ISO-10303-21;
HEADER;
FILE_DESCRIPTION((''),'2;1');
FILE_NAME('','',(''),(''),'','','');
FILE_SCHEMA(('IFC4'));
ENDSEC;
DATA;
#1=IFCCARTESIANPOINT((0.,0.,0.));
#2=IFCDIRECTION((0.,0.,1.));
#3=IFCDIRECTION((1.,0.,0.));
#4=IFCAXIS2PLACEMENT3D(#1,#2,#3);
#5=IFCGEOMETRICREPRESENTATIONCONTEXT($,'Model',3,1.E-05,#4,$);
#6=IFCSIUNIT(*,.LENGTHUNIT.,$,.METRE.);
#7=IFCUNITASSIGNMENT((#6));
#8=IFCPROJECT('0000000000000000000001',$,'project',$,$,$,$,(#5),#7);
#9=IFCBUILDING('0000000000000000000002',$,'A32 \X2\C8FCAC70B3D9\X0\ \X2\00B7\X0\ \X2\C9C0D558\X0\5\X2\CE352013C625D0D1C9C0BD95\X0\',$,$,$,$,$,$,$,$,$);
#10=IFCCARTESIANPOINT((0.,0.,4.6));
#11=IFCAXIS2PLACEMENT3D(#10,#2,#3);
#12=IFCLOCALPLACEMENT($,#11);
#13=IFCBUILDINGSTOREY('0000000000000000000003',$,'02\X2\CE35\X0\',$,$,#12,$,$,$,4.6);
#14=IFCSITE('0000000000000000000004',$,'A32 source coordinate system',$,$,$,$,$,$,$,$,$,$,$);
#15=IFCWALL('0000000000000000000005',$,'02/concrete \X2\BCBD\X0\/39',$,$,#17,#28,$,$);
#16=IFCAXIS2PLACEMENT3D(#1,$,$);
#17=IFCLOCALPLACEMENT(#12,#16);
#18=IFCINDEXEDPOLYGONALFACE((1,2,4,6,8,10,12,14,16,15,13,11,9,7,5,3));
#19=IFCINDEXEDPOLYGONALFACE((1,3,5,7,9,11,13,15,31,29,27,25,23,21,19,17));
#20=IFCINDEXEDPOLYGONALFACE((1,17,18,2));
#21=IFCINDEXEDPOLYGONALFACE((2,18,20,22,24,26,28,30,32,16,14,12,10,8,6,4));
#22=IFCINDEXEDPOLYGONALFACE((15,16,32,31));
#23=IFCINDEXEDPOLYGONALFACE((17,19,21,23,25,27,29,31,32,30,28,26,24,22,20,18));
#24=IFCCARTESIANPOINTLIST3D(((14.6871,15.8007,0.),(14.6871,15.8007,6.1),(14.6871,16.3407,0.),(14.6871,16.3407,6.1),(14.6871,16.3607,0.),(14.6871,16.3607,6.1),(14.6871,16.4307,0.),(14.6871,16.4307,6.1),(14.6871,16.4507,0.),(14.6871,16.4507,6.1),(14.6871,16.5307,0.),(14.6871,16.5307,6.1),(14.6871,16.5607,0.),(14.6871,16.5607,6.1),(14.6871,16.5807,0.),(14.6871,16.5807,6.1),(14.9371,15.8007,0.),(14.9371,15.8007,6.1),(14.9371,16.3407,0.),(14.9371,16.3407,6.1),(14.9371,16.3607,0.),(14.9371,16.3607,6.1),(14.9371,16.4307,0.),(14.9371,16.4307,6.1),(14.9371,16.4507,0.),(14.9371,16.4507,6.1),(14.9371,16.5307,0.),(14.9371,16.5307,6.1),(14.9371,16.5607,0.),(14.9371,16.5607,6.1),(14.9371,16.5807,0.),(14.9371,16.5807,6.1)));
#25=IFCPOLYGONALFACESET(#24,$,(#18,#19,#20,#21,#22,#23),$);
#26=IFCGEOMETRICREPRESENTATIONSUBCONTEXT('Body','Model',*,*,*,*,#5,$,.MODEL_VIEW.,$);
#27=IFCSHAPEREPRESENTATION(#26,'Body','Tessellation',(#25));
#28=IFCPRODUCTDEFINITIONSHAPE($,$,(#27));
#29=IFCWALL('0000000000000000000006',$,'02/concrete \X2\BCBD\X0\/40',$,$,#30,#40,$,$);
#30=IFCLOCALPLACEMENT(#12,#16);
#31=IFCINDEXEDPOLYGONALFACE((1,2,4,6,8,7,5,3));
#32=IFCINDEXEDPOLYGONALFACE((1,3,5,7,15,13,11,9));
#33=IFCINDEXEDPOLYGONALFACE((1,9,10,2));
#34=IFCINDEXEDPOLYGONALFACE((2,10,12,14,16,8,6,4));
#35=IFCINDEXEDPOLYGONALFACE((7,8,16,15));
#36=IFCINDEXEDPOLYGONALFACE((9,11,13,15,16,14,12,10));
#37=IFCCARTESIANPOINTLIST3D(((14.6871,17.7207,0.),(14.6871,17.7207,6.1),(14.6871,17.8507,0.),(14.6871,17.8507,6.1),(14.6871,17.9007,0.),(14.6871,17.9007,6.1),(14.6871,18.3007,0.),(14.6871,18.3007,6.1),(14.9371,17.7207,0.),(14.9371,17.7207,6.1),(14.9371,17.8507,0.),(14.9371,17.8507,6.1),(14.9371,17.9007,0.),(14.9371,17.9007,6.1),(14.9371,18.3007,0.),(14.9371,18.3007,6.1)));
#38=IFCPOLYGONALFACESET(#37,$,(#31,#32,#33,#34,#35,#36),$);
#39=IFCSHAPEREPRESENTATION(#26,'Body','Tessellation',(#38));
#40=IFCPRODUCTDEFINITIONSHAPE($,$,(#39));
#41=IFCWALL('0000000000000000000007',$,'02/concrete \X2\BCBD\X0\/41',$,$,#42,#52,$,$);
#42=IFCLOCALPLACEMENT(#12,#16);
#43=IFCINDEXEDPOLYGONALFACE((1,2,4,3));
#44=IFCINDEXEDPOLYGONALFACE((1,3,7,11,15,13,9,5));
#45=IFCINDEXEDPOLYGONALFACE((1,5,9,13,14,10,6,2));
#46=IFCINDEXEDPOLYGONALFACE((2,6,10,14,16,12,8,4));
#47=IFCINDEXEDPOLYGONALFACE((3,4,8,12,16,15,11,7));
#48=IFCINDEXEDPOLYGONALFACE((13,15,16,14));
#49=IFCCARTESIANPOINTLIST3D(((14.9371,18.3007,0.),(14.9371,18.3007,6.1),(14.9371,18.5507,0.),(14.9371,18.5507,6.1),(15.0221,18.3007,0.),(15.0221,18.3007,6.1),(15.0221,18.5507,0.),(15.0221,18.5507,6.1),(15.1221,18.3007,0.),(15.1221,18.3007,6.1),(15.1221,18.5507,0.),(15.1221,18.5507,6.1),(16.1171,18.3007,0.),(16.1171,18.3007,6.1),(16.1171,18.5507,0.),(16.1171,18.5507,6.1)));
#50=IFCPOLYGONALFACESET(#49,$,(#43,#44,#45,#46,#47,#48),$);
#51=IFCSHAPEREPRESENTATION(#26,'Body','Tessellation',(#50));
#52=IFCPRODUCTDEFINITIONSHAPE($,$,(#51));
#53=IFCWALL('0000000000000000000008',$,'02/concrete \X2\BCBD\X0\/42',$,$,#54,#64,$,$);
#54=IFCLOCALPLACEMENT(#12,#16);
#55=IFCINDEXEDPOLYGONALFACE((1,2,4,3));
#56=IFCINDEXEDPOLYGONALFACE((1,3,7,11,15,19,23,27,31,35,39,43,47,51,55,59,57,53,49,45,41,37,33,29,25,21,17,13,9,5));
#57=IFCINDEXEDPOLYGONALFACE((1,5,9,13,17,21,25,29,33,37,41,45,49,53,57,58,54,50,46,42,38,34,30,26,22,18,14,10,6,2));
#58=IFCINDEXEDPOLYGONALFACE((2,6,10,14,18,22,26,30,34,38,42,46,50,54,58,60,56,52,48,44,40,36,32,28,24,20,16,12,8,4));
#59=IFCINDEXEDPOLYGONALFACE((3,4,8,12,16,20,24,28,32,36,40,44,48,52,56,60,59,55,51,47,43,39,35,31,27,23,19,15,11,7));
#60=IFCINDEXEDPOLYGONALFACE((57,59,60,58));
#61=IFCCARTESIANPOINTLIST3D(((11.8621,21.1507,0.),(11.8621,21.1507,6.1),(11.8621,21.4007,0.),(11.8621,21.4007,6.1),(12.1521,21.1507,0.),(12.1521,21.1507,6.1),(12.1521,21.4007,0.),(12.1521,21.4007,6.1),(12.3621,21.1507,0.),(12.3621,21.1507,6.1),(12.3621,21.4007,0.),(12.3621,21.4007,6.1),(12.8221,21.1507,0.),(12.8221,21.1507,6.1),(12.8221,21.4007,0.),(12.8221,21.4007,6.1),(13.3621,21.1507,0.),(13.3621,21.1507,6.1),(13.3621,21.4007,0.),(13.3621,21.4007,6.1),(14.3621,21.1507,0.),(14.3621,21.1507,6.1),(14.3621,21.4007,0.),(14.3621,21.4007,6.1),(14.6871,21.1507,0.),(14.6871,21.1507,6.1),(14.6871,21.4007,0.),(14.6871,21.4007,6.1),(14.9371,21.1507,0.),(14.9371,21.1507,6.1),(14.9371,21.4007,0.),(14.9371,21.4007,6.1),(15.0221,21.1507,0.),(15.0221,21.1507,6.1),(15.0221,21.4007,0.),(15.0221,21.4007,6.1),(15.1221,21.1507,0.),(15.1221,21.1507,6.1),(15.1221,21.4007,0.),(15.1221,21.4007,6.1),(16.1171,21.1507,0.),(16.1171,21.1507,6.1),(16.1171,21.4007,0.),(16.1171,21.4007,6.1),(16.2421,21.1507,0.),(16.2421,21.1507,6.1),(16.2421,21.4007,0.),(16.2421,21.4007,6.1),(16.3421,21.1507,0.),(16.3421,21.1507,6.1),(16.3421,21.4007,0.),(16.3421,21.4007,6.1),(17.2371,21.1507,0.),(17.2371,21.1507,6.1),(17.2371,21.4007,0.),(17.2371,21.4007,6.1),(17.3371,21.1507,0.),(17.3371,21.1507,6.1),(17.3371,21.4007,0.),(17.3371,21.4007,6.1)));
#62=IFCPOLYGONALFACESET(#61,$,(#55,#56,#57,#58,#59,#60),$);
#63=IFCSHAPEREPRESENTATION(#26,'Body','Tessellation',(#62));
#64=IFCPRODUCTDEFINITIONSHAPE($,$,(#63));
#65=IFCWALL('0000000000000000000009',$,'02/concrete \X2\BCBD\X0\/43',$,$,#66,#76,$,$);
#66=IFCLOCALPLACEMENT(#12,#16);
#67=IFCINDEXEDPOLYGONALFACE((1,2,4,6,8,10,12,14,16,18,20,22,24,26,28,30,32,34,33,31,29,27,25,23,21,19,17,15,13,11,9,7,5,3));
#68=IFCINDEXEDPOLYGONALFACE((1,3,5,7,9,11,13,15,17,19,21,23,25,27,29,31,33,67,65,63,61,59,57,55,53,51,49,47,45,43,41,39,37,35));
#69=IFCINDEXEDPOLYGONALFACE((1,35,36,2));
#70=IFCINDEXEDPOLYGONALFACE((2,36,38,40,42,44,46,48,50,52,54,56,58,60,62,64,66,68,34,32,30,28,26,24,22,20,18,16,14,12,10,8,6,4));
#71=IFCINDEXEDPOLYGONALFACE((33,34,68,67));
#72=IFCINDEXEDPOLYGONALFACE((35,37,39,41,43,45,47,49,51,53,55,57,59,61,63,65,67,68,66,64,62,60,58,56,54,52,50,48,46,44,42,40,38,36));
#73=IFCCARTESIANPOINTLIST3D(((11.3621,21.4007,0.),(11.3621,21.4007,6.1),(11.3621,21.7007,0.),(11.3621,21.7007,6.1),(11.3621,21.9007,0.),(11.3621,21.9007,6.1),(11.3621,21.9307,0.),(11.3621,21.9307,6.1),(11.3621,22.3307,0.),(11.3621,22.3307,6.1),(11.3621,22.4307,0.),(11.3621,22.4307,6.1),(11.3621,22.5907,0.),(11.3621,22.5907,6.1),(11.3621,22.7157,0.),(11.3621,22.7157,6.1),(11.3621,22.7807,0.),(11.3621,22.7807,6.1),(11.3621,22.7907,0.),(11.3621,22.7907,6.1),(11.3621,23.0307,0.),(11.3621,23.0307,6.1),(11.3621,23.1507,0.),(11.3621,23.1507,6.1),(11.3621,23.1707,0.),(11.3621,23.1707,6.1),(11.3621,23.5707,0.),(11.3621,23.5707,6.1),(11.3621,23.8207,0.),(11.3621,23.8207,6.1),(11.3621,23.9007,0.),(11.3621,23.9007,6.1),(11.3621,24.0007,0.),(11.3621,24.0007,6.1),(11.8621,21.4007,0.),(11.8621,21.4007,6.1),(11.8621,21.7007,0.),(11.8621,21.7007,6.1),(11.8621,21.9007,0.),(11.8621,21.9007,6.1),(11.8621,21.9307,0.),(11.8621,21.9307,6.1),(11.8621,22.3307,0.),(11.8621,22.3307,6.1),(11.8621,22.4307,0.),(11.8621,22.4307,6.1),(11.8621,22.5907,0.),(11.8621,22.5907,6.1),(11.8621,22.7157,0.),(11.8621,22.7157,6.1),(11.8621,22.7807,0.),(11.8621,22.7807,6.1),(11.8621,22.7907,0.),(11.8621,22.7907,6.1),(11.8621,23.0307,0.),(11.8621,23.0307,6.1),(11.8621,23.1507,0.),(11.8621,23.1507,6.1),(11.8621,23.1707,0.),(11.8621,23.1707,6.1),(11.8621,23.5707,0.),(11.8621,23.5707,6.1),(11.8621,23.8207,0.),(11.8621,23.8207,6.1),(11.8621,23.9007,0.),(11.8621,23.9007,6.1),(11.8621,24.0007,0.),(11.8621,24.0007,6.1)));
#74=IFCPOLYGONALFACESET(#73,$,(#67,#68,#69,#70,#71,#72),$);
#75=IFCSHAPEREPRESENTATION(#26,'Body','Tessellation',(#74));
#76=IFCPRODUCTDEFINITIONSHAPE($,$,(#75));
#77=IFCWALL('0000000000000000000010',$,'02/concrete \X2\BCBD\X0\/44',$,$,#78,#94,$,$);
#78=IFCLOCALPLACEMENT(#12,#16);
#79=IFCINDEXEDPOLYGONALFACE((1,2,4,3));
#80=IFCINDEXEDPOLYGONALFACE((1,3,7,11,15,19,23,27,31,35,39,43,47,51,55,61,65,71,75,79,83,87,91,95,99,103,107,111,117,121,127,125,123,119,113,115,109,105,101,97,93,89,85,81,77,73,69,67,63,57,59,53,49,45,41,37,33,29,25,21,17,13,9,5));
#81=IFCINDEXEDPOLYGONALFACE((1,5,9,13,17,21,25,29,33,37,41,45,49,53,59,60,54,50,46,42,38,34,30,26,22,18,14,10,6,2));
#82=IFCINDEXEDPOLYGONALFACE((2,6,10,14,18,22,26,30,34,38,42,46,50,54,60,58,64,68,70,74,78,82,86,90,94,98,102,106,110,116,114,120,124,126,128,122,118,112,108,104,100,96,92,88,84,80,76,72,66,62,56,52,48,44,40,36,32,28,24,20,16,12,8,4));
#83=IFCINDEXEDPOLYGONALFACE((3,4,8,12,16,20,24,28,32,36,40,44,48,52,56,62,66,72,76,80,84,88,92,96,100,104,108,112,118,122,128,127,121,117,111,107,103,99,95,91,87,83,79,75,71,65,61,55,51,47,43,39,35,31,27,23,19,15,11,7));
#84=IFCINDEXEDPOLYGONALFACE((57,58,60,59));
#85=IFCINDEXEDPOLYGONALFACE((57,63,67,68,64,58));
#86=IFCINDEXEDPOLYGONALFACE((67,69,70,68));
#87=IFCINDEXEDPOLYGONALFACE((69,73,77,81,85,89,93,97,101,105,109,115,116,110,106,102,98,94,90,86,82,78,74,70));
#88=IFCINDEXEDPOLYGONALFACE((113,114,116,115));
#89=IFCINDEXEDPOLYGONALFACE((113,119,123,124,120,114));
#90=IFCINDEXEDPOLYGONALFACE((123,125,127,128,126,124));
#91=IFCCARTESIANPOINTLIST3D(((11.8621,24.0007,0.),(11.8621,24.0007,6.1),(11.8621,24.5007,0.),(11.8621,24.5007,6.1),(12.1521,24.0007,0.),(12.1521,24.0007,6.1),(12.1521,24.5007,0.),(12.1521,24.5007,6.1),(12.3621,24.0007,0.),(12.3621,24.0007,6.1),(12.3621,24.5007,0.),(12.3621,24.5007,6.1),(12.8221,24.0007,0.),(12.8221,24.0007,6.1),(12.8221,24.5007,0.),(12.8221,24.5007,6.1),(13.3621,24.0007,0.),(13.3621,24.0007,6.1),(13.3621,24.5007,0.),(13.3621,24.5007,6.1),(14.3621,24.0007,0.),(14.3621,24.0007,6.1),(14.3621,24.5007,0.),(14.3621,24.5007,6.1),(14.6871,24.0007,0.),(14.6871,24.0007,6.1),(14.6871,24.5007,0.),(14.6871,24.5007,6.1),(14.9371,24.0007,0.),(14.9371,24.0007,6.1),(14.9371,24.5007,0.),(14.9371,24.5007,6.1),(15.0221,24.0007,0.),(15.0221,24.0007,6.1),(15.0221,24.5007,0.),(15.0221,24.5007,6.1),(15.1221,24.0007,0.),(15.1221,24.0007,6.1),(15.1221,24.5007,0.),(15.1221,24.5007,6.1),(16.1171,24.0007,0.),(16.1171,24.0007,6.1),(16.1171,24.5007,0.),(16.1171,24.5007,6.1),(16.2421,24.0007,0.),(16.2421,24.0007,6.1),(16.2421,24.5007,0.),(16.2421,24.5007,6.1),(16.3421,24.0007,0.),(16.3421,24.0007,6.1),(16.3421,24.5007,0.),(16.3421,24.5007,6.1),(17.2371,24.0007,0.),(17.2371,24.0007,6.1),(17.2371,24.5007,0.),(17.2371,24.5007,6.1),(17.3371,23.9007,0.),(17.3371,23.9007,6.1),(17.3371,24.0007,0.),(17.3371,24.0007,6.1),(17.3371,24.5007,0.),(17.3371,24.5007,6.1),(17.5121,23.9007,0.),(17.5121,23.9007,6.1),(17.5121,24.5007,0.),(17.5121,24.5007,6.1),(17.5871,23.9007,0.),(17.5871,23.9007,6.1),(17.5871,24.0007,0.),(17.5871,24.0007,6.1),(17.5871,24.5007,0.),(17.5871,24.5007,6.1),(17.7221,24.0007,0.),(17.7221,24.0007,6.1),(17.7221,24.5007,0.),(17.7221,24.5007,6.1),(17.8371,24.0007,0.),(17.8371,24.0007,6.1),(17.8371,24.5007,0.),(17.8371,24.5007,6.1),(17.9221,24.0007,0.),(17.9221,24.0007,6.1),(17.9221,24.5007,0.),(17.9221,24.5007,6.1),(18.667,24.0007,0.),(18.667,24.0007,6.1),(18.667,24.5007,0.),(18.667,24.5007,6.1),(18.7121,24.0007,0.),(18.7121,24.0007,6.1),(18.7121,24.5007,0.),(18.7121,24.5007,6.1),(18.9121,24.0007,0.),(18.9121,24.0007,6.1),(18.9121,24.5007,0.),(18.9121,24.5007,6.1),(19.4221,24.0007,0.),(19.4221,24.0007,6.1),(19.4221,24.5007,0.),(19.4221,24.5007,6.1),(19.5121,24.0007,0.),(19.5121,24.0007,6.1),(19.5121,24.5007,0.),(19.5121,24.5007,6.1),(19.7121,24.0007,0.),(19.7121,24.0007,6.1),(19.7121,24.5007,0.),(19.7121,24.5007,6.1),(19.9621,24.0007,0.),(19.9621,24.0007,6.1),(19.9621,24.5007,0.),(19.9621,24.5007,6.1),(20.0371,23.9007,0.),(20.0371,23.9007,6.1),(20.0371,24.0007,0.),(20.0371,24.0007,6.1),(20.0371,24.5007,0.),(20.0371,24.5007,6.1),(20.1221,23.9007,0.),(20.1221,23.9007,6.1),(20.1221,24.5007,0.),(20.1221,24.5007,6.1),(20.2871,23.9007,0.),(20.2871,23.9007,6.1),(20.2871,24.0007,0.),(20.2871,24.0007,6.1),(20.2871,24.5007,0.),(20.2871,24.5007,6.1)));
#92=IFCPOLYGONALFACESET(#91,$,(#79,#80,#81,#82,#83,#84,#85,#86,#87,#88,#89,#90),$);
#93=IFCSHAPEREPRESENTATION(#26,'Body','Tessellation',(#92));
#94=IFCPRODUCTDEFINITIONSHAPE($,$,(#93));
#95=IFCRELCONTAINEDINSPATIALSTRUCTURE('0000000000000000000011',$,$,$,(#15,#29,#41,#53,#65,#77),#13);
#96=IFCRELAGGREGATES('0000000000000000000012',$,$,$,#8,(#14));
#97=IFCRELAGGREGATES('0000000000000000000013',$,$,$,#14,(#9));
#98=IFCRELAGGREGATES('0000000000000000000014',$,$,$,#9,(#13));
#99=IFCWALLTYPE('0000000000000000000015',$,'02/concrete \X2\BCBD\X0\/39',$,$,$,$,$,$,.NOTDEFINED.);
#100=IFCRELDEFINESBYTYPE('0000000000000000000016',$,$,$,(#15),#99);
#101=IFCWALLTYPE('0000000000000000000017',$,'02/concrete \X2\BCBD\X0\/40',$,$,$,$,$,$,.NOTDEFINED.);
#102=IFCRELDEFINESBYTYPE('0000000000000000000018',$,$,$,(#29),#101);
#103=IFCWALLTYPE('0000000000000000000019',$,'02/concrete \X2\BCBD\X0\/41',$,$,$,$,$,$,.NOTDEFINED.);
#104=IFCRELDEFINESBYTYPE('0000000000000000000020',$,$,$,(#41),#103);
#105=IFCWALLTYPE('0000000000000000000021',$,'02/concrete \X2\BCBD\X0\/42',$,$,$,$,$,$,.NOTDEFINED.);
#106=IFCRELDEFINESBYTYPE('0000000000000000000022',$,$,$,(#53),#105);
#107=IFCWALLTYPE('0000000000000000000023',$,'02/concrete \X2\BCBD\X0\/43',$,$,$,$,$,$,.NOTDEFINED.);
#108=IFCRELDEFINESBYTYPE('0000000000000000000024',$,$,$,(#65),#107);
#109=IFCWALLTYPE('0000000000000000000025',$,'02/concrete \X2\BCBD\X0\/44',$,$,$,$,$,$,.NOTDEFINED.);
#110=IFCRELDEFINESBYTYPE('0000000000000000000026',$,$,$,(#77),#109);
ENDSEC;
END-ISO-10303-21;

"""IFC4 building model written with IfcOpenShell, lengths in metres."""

from ifc_helpers import new_model, si_unit, frame, origin, origin_with_axes, place, context, subcontext, project, spatial, polyline, outline, extrude, source, transform, mapped, type_object, type_shapes, element, save


model = new_model("IFC4")

# Units and contexts
model_context = context("Model", 3, precision=1e-05, world=origin_with_axes())
body_context = subcontext(model_context, "Body", "Model", "MODEL_VIEW")
ifc_project = project(units=[si_unit("LENGTHUNIT", "METRE")], contexts=[model_context])

# Site, building, storey
site = spatial("IfcSite", under=ifc_project, Name="A32 source coordinate system")
building = spatial("IfcBuilding", under=site, Name="A32 주거동 · 지하5층–옥탑지붕")
storey_placement = place(None, frame((0.0, 0.0, 4.6), z_axis=(0.0, 0.0, 1.0), x_axis=(1.0, 0.0, 0.0)))
storey = spatial("IfcBuildingStorey", under=building, at=storey_placement, Name="02층", Elevation=4.6)

# Walls
wall_type_1 = type_object("IfcWallType", Name="02/concrete 벽/39", PredefinedType="NOTDEFINED")
shared_shape_1 = source(origin(), body_context, "Body", "SweptSolid", [
    extrude(outline(polyline([(14.6871, 16.4307), (14.6871, 16.4507), (14.6871, 16.5307), (14.6871, 16.5607), (14.6871, 16.5807), (14.9371, 16.5807), (14.9371, 16.5607), (14.9371, 16.5307), (14.9371, 16.4507), (14.9371, 16.4307), (14.9371, 16.3607), (14.9371, 16.3407), (14.9371, 15.8007), (14.6871, 15.8007), (14.6871, 16.3407), (14.6871, 16.3607), (14.6871, 16.4307)])), origin(), (0.0, 0.0, 1.0), 6.1),
])
type_shapes(wall_type_1, [shared_shape_1])
wall_1_placement = place(storey_placement, origin_with_axes())
element("IfcWall", 1, at=wall_1_placement, inside=storey, type_object=wall_type_1, Name="02/concrete 벽/39", context=body_context, shape_type="MappedRepresentation", body=[
    mapped(shared_shape_1, transform((0.0, 0.0, 0.0), scale=1.0)),
])
wall_type_2 = type_object("IfcWallType", Name="02/concrete 벽/40", PredefinedType="NOTDEFINED")
shared_shape_2 = source(origin(), body_context, "Body", "SweptSolid", [
    extrude(outline(polyline([(14.9371, 17.8507), (14.9371, 17.7207), (14.6871, 17.7207), (14.6871, 17.8507), (14.6871, 17.9007), (14.6871, 18.3007), (14.9371, 18.3007), (14.9371, 17.9007), (14.9371, 17.8507)])), origin(), (0.0, 0.0, 1.0), 6.1),
])
type_shapes(wall_type_2, [shared_shape_2])
wall_2_placement = place(storey_placement, origin_with_axes())
element("IfcWall", 2, at=wall_2_placement, inside=storey, type_object=wall_type_2, Name="02/concrete 벽/40", context=body_context, shape_type="MappedRepresentation", body=[
    mapped(shared_shape_2, transform((0.0, 0.0, 0.0), scale=1.0)),
])
wall_type_3 = type_object("IfcWallType", Name="02/concrete 벽/41", PredefinedType="NOTDEFINED")
shared_shape_3 = source(origin(), body_context, "Body", "SweptSolid", [
    extrude(outline(polyline([(15.1221, 18.5507), (16.1171, 18.5507), (16.1171, 18.3007), (15.1221, 18.3007), (15.0221, 18.3007), (14.9371, 18.3007), (14.9371, 18.5507), (15.0221, 18.5507), (15.1221, 18.5507)])), origin(), (0.0, 0.0, 1.0), 6.1),
])
type_shapes(wall_type_3, [shared_shape_3])
wall_3_placement = place(storey_placement, origin_with_axes())
element("IfcWall", 3, at=wall_3_placement, inside=storey, type_object=wall_type_3, Name="02/concrete 벽/41", context=body_context, shape_type="MappedRepresentation", body=[
    mapped(shared_shape_3, transform((0.0, 0.0, 0.0), scale=1.0)),
])
wall_type_4 = type_object("IfcWallType", Name="02/concrete 벽/42", PredefinedType="NOTDEFINED")
shared_shape_4 = source(origin(), body_context, "Body", "SweptSolid", [
    extrude(outline(polyline([(12.3621, 21.4007), (12.8221, 21.4007), (13.3621, 21.4007), (14.3621, 21.4007), (14.6871, 21.4007), (14.9371, 21.4007), (15.0221, 21.4007), (15.1221, 21.4007), (16.1171, 21.4007), (16.2421, 21.4007), (16.3421, 21.4007), (17.2371, 21.4007), (17.3371, 21.4007), (17.3371, 21.1507), (17.2371, 21.1507), (16.3421, 21.1507), (16.2421, 21.1507), (16.1171, 21.1507), (15.1221, 21.1507), (15.0221, 21.1507), (14.9371, 21.1507), (14.6871, 21.1507), (14.3621, 21.1507), (13.3621, 21.1507), (12.8221, 21.1507), (12.3621, 21.1507), (12.1521, 21.1507), (11.8621, 21.1507), (11.8621, 21.4007), (12.1521, 21.4007), (12.3621, 21.4007)])), origin(), (0.0, 0.0, 1.0), 6.1),
])
type_shapes(wall_type_4, [shared_shape_4])
wall_4_placement = place(storey_placement, origin_with_axes())
element("IfcWall", 4, at=wall_4_placement, inside=storey, type_object=wall_type_4, Name="02/concrete 벽/42", context=body_context, shape_type="MappedRepresentation", body=[
    mapped(shared_shape_4, transform((0.0, 0.0, 0.0), scale=1.0)),
])
wall_type_5 = type_object("IfcWallType", Name="02/concrete 벽/43", PredefinedType="NOTDEFINED")
shared_shape_5 = source(origin(), body_context, "Body", "SweptSolid", [
    extrude(outline(polyline([(11.3621, 21.9007), (11.3621, 21.9307), (11.3621, 22.3307), (11.3621, 22.4307), (11.3621, 22.5907), (11.3621, 22.7157), (11.3621, 22.7807), (11.3621, 22.7907), (11.3621, 23.0307), (11.3621, 23.1507), (11.3621, 23.1707), (11.3621, 23.5707), (11.3621, 23.8207), (11.3621, 23.9007), (11.3621, 24.0007), (11.8621, 24.0007), (11.8621, 23.9007), (11.8621, 23.8207), (11.8621, 23.5707), (11.8621, 23.1707), (11.8621, 23.1507), (11.8621, 23.0307), (11.8621, 22.7907), (11.8621, 22.7807), (11.8621, 22.7157), (11.8621, 22.5907), (11.8621, 22.4307), (11.8621, 22.3307), (11.8621, 21.9307), (11.8621, 21.9007), (11.8621, 21.7007), (11.8621, 21.4007), (11.3621, 21.4007), (11.3621, 21.7007), (11.3621, 21.9007)])), origin(), (0.0, 0.0, 1.0), 6.1),
])
type_shapes(wall_type_5, [shared_shape_5])
wall_5_placement = place(storey_placement, origin_with_axes())
element("IfcWall", 5, at=wall_5_placement, inside=storey, type_object=wall_type_5, Name="02/concrete 벽/43", context=body_context, shape_type="MappedRepresentation", body=[
    mapped(shared_shape_5, transform((0.0, 0.0, 0.0), scale=1.0)),
])
wall_type_6 = type_object("IfcWallType", Name="02/concrete 벽/44", PredefinedType="NOTDEFINED")
shared_shape_6 = source(origin(), body_context, "Body", "SweptSolid", [
    extrude(outline(polyline([(12.3621, 24.5007), (12.8221, 24.5007), (13.3621, 24.5007), (14.3621, 24.5007), (14.6871, 24.5007), (14.9371, 24.5007), (15.0221, 24.5007), (15.1221, 24.5007), (16.1171, 24.5007), (16.2421, 24.5007), (16.3421, 24.5007), (17.2371, 24.5007), (17.3371, 24.5007), (17.5121, 24.5007), (17.5871, 24.5007), (17.7221, 24.5007), (17.8371, 24.5007), (17.9221, 24.5007), (18.667, 24.5007), (18.7121, 24.5007), (18.9121, 24.5007), (19.4221, 24.5007), (19.5121, 24.5007), (19.7121, 24.5007), (19.9621, 24.5007), (20.0371, 24.5007), (20.1221, 24.5007), (20.2871, 24.5007), (20.2871, 24.0007), (20.2871, 23.9007), (20.1221, 23.9007), (20.0371, 23.9007), (20.0371, 24.0007), (19.9621, 24.0007), (19.7121, 24.0007), (19.5121, 24.0007), (19.4221, 24.0007), (18.9121, 24.0007), (18.7121, 24.0007), (18.667, 24.0007), (17.9221, 24.0007), (17.8371, 24.0007), (17.7221, 24.0007), (17.5871, 24.0007), (17.5871, 23.9007), (17.5121, 23.9007), (17.3371, 23.9007), (17.3371, 24.0007), (17.2371, 24.0007), (16.3421, 24.0007), (16.2421, 24.0007), (16.1171, 24.0007), (15.1221, 24.0007), (15.0221, 24.0007), (14.9371, 24.0007), (14.6871, 24.0007), (14.3621, 24.0007), (13.3621, 24.0007), (12.8221, 24.0007), (12.3621, 24.0007), (12.1521, 24.0007), (11.8621, 24.0007), (11.8621, 24.5007), (12.1521, 24.5007), (12.3621, 24.5007)])), origin(), (0.0, 0.0, 1.0), 6.1),
])
type_shapes(wall_type_6, [shared_shape_6])
wall_6_placement = place(storey_placement, origin_with_axes())
element("IfcWall", 6, at=wall_6_placement, inside=storey, type_object=wall_type_6, Name="02/concrete 벽/44", context=body_context, shape_type="MappedRepresentation", body=[
    mapped(shared_shape_6, transform((0.0, 0.0, 0.0), scale=1.0)),
])

save(model, "model.ifc")
